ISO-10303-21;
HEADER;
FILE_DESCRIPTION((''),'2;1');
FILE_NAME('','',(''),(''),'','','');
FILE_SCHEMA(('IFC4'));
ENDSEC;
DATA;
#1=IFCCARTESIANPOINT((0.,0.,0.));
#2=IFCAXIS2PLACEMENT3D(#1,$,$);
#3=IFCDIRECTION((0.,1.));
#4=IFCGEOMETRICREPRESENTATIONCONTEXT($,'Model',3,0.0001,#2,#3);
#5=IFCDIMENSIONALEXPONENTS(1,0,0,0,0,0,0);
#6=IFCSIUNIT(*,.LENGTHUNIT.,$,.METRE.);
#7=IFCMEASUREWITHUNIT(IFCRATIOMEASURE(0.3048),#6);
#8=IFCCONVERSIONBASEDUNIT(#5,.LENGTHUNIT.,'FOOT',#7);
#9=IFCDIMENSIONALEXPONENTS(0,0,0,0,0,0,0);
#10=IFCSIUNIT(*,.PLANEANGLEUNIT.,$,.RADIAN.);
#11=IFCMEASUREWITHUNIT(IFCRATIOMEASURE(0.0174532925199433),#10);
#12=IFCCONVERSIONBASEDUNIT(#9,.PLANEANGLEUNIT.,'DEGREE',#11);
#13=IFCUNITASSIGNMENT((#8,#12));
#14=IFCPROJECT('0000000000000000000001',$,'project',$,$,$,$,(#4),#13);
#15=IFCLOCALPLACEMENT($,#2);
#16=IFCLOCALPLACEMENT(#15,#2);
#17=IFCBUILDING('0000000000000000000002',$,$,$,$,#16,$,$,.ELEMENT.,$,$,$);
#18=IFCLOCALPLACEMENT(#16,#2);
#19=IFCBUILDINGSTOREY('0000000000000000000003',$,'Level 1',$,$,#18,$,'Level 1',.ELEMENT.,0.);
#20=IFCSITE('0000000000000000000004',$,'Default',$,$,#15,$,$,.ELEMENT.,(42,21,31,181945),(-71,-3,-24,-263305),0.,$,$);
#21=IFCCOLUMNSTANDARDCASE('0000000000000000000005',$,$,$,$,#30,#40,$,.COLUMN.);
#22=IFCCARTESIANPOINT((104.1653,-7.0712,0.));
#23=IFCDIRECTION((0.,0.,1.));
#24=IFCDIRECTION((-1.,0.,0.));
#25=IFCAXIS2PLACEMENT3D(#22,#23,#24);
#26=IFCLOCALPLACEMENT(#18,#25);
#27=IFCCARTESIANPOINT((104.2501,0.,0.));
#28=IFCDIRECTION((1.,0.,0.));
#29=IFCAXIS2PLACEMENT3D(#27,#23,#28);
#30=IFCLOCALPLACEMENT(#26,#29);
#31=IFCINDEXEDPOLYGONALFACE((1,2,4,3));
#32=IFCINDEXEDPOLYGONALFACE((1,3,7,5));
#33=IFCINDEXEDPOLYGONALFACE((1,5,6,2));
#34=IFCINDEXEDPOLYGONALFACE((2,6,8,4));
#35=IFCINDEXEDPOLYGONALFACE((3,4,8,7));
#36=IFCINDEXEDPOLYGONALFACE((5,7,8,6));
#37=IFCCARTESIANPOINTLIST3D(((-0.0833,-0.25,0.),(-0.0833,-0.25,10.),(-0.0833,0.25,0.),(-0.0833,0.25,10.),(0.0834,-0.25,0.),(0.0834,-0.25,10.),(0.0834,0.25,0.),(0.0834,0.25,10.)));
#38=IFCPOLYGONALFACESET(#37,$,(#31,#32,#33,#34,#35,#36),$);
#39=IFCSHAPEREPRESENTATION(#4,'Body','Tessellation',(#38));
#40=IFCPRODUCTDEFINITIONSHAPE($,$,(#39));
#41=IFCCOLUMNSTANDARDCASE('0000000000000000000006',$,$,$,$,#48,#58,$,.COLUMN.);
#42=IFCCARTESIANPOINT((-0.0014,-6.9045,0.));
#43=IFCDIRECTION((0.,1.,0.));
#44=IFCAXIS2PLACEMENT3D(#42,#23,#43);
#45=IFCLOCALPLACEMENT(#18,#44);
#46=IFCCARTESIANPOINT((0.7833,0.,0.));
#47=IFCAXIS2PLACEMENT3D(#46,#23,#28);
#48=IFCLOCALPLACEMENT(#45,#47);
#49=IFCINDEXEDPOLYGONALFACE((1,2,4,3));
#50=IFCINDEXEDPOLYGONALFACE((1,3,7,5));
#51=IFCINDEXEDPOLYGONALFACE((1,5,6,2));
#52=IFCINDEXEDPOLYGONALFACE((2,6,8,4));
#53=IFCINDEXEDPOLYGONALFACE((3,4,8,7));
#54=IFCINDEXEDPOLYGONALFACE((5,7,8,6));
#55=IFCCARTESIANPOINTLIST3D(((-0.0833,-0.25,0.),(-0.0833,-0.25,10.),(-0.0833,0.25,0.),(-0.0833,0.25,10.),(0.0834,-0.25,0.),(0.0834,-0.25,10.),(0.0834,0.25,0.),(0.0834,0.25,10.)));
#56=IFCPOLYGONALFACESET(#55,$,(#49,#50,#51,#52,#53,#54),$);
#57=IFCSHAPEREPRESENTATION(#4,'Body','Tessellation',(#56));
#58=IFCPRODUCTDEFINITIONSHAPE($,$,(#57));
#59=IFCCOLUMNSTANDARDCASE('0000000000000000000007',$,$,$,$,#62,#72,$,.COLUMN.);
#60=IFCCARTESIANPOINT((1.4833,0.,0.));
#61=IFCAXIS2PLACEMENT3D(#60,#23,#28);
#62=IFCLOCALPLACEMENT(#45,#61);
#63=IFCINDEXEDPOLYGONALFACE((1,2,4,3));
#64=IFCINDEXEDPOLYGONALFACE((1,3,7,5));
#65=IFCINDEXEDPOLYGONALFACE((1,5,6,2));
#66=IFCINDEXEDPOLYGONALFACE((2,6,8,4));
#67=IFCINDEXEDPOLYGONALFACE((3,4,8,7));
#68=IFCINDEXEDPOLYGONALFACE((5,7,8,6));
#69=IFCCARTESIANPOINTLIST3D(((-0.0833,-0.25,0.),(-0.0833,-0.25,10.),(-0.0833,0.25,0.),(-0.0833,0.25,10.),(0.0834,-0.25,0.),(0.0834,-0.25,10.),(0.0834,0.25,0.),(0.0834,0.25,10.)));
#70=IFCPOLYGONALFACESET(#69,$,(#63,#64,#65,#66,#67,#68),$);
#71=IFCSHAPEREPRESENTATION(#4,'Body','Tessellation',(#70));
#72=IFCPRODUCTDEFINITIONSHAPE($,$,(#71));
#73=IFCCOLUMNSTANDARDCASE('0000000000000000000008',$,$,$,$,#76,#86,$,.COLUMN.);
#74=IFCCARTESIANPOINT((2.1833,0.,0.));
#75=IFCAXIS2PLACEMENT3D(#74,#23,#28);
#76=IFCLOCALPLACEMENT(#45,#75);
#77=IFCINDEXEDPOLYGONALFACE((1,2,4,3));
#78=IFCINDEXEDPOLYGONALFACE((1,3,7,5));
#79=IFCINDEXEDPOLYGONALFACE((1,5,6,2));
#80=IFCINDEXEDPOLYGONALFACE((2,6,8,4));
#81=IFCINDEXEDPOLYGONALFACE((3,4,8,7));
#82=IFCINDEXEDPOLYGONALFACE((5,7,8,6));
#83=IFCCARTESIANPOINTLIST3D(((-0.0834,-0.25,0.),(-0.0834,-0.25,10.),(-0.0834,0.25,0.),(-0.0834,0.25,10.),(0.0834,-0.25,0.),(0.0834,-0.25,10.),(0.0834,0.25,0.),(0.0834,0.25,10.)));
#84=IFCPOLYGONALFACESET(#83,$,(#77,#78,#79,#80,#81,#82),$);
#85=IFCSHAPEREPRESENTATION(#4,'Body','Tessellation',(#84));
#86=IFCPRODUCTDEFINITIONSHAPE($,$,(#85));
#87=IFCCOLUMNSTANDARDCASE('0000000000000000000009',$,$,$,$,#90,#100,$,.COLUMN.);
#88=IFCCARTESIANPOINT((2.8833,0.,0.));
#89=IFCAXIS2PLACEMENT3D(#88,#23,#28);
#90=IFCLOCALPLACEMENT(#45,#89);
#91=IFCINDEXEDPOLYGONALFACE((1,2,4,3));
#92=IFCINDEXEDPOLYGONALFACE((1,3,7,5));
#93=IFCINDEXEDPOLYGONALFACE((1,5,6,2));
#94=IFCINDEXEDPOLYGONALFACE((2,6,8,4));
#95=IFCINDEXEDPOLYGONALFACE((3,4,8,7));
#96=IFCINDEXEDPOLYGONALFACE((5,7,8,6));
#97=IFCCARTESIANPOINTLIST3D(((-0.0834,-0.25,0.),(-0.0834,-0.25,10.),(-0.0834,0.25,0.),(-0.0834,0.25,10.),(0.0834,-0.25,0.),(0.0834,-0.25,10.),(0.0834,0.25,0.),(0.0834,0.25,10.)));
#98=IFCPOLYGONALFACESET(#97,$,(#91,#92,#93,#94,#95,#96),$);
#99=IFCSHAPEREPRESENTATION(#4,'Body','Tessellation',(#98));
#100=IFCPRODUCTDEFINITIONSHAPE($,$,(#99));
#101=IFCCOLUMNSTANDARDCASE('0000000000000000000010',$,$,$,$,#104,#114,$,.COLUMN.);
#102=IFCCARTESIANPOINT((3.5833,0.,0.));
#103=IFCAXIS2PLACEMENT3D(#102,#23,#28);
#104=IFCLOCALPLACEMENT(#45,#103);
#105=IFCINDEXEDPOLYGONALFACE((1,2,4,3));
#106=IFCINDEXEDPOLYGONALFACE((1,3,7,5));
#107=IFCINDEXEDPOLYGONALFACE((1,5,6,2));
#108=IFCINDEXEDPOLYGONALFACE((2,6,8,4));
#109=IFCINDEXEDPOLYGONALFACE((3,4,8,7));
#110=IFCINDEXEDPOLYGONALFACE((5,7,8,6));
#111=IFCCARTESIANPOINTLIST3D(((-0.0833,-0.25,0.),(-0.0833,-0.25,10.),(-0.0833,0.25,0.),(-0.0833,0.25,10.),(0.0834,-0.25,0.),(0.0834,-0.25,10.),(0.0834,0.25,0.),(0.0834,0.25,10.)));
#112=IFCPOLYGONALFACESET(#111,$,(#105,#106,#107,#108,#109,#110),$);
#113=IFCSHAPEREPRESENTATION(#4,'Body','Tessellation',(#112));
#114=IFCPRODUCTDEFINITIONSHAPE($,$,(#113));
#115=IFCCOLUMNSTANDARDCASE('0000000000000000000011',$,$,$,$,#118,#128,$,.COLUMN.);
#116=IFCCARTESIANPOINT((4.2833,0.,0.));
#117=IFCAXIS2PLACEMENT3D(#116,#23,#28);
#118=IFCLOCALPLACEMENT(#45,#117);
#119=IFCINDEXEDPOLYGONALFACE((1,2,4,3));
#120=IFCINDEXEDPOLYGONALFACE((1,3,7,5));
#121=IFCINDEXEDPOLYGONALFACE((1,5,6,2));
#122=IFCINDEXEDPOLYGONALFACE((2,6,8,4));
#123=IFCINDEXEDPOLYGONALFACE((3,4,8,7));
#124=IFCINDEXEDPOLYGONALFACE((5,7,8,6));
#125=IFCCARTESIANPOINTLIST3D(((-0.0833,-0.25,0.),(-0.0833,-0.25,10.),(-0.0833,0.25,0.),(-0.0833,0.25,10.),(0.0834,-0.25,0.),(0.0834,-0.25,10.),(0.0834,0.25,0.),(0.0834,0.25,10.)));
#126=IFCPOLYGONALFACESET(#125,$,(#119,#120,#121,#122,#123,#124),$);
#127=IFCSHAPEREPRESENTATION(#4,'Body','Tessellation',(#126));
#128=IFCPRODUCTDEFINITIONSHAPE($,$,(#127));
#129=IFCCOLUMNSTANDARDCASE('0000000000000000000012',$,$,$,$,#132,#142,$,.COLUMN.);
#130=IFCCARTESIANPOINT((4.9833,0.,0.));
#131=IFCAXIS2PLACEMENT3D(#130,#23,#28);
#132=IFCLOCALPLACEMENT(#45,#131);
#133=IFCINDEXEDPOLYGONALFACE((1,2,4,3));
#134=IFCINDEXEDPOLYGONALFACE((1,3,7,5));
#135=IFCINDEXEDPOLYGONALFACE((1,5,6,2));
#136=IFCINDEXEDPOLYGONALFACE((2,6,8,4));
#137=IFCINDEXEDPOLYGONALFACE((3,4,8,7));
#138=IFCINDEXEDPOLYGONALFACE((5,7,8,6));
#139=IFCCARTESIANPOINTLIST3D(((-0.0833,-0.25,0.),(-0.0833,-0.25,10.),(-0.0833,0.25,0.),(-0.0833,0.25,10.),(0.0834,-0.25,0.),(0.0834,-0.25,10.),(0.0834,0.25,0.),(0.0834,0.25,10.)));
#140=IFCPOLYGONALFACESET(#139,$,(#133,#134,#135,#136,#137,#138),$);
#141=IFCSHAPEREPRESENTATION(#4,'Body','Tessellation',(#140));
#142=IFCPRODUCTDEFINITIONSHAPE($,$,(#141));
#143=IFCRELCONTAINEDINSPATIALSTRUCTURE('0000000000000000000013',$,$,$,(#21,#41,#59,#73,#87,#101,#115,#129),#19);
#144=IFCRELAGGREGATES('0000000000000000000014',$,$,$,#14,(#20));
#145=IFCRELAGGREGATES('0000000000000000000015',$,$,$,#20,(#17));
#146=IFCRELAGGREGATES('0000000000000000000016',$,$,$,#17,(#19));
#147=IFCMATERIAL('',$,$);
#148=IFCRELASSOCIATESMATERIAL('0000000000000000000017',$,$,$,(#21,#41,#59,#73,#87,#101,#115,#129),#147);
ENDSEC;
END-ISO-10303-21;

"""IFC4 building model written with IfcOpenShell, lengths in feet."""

from ifc_helpers import new_model, entity, si_unit, converted_unit, direction, frame, origin, place, context, project, spatial, rectangle, extrude, material, element, save


model = new_model("IFC4")

# Units and contexts
model_context = context("Model", 3, precision=0.0001, world=origin(), true_north=direction((0.0, 1.0)))
ifc_project = project(units=[converted_unit("LENGTHUNIT", "FOOT", entity("IfcRatioMeasure", 0.3048), si_unit("LENGTHUNIT", "METRE"), dimensions=[1, 0, 0, 0, 0, 0, 0]), converted_unit("PLANEANGLEUNIT", "DEGREE", entity("IfcRatioMeasure", 0.0174532925199433), si_unit("PLANEANGLEUNIT", "RADIAN"), dimensions=[0, 0, 0, 0, 0, 0, 0])], contexts=[model_context])

# Site, building, storey
site_placement = place(None, origin())
site = spatial("IfcSite", under=ifc_project, at=site_placement, Name="Default", CompositionType="ELEMENT", RefLatitude=(42, 21, 31, 181945), RefLongitude=(-71, -3, -24, -263305), RefElevation=0.0)
building_placement = place(site_placement, origin())
building = spatial("IfcBuilding", under=site, at=building_placement, CompositionType="ELEMENT")
storey_placement = place(building_placement, origin())
storey = spatial("IfcBuildingStorey", under=building, at=storey_placement, Name="Level 1", LongName="Level 1", CompositionType="ELEMENT", Elevation=0.0)

# Columns
ifc_material_1 = material(Name="")
placement_1 = place(storey_placement, frame((104.1653, -7.0712, 0.0), z_axis=(0.0, 0.0, 1.0), x_axis=(-1.0, 0.0, 0.0)))
for number, where, z_axis, x_axis in (
    (1, (104.2501, 0.0, 0.0), (0.0, 0.0, 1.0), (1.0, 0.0, 0.0)),
):
    element("IfcColumnStandardCase", number, at=place(placement_1, frame(where, z_axis=z_axis, x_axis=x_axis)), inside=storey, material=ifc_material_1, PredefinedType="COLUMN", context=model_context, shape_type="SweptSolid", body=[
        extrude(rectangle(XDim=0.1667, YDim=0.5), origin(), (0.0, 0.0, 1.0), 10.0),
    ])
placement_2 = place(storey_placement, frame((-0.0014, -6.9045, 0.0), z_axis=(0.0, 0.0, 1.0), x_axis=(0.0, 1.0, 0.0)))
for number, where, z_axis, x_axis in (
    (2, (0.7833, 0.0, 0.0), (0.0, 0.0, 1.0), (1.0, 0.0, 0.0)),
    (3, (1.4833, 0.0, 0.0), (0.0, 0.0, 1.0), (1.0, 0.0, 0.0)),
    (4, (2.1833, 0.0, 0.0), (0.0, 0.0, 1.0), (1.0, 0.0, 0.0)),
    (5, (2.8833, 0.0, 0.0), (0.0, 0.0, 1.0), (1.0, 0.0, 0.0)),
    (6, (3.5833, 0.0, 0.0), (0.0, 0.0, 1.0), (1.0, 0.0, 0.0)),
    (7, (4.2833, 0.0, 0.0), (0.0, 0.0, 1.0), (1.0, 0.0, 0.0)),
    (8, (4.9833, 0.0, 0.0), (0.0, 0.0, 1.0), (1.0, 0.0, 0.0)),
):
    element("IfcColumnStandardCase", number, at=place(placement_2, frame(where, z_axis=z_axis, x_axis=x_axis)), inside=storey, material=ifc_material_1, PredefinedType="COLUMN", context=model_context, shape_type="SweptSolid", body=[
        extrude(rectangle(XDim=0.1667, YDim=0.5), origin(), (0.0, 0.0, 1.0), 10.0),
    ])

save(model, "model.ifc")
